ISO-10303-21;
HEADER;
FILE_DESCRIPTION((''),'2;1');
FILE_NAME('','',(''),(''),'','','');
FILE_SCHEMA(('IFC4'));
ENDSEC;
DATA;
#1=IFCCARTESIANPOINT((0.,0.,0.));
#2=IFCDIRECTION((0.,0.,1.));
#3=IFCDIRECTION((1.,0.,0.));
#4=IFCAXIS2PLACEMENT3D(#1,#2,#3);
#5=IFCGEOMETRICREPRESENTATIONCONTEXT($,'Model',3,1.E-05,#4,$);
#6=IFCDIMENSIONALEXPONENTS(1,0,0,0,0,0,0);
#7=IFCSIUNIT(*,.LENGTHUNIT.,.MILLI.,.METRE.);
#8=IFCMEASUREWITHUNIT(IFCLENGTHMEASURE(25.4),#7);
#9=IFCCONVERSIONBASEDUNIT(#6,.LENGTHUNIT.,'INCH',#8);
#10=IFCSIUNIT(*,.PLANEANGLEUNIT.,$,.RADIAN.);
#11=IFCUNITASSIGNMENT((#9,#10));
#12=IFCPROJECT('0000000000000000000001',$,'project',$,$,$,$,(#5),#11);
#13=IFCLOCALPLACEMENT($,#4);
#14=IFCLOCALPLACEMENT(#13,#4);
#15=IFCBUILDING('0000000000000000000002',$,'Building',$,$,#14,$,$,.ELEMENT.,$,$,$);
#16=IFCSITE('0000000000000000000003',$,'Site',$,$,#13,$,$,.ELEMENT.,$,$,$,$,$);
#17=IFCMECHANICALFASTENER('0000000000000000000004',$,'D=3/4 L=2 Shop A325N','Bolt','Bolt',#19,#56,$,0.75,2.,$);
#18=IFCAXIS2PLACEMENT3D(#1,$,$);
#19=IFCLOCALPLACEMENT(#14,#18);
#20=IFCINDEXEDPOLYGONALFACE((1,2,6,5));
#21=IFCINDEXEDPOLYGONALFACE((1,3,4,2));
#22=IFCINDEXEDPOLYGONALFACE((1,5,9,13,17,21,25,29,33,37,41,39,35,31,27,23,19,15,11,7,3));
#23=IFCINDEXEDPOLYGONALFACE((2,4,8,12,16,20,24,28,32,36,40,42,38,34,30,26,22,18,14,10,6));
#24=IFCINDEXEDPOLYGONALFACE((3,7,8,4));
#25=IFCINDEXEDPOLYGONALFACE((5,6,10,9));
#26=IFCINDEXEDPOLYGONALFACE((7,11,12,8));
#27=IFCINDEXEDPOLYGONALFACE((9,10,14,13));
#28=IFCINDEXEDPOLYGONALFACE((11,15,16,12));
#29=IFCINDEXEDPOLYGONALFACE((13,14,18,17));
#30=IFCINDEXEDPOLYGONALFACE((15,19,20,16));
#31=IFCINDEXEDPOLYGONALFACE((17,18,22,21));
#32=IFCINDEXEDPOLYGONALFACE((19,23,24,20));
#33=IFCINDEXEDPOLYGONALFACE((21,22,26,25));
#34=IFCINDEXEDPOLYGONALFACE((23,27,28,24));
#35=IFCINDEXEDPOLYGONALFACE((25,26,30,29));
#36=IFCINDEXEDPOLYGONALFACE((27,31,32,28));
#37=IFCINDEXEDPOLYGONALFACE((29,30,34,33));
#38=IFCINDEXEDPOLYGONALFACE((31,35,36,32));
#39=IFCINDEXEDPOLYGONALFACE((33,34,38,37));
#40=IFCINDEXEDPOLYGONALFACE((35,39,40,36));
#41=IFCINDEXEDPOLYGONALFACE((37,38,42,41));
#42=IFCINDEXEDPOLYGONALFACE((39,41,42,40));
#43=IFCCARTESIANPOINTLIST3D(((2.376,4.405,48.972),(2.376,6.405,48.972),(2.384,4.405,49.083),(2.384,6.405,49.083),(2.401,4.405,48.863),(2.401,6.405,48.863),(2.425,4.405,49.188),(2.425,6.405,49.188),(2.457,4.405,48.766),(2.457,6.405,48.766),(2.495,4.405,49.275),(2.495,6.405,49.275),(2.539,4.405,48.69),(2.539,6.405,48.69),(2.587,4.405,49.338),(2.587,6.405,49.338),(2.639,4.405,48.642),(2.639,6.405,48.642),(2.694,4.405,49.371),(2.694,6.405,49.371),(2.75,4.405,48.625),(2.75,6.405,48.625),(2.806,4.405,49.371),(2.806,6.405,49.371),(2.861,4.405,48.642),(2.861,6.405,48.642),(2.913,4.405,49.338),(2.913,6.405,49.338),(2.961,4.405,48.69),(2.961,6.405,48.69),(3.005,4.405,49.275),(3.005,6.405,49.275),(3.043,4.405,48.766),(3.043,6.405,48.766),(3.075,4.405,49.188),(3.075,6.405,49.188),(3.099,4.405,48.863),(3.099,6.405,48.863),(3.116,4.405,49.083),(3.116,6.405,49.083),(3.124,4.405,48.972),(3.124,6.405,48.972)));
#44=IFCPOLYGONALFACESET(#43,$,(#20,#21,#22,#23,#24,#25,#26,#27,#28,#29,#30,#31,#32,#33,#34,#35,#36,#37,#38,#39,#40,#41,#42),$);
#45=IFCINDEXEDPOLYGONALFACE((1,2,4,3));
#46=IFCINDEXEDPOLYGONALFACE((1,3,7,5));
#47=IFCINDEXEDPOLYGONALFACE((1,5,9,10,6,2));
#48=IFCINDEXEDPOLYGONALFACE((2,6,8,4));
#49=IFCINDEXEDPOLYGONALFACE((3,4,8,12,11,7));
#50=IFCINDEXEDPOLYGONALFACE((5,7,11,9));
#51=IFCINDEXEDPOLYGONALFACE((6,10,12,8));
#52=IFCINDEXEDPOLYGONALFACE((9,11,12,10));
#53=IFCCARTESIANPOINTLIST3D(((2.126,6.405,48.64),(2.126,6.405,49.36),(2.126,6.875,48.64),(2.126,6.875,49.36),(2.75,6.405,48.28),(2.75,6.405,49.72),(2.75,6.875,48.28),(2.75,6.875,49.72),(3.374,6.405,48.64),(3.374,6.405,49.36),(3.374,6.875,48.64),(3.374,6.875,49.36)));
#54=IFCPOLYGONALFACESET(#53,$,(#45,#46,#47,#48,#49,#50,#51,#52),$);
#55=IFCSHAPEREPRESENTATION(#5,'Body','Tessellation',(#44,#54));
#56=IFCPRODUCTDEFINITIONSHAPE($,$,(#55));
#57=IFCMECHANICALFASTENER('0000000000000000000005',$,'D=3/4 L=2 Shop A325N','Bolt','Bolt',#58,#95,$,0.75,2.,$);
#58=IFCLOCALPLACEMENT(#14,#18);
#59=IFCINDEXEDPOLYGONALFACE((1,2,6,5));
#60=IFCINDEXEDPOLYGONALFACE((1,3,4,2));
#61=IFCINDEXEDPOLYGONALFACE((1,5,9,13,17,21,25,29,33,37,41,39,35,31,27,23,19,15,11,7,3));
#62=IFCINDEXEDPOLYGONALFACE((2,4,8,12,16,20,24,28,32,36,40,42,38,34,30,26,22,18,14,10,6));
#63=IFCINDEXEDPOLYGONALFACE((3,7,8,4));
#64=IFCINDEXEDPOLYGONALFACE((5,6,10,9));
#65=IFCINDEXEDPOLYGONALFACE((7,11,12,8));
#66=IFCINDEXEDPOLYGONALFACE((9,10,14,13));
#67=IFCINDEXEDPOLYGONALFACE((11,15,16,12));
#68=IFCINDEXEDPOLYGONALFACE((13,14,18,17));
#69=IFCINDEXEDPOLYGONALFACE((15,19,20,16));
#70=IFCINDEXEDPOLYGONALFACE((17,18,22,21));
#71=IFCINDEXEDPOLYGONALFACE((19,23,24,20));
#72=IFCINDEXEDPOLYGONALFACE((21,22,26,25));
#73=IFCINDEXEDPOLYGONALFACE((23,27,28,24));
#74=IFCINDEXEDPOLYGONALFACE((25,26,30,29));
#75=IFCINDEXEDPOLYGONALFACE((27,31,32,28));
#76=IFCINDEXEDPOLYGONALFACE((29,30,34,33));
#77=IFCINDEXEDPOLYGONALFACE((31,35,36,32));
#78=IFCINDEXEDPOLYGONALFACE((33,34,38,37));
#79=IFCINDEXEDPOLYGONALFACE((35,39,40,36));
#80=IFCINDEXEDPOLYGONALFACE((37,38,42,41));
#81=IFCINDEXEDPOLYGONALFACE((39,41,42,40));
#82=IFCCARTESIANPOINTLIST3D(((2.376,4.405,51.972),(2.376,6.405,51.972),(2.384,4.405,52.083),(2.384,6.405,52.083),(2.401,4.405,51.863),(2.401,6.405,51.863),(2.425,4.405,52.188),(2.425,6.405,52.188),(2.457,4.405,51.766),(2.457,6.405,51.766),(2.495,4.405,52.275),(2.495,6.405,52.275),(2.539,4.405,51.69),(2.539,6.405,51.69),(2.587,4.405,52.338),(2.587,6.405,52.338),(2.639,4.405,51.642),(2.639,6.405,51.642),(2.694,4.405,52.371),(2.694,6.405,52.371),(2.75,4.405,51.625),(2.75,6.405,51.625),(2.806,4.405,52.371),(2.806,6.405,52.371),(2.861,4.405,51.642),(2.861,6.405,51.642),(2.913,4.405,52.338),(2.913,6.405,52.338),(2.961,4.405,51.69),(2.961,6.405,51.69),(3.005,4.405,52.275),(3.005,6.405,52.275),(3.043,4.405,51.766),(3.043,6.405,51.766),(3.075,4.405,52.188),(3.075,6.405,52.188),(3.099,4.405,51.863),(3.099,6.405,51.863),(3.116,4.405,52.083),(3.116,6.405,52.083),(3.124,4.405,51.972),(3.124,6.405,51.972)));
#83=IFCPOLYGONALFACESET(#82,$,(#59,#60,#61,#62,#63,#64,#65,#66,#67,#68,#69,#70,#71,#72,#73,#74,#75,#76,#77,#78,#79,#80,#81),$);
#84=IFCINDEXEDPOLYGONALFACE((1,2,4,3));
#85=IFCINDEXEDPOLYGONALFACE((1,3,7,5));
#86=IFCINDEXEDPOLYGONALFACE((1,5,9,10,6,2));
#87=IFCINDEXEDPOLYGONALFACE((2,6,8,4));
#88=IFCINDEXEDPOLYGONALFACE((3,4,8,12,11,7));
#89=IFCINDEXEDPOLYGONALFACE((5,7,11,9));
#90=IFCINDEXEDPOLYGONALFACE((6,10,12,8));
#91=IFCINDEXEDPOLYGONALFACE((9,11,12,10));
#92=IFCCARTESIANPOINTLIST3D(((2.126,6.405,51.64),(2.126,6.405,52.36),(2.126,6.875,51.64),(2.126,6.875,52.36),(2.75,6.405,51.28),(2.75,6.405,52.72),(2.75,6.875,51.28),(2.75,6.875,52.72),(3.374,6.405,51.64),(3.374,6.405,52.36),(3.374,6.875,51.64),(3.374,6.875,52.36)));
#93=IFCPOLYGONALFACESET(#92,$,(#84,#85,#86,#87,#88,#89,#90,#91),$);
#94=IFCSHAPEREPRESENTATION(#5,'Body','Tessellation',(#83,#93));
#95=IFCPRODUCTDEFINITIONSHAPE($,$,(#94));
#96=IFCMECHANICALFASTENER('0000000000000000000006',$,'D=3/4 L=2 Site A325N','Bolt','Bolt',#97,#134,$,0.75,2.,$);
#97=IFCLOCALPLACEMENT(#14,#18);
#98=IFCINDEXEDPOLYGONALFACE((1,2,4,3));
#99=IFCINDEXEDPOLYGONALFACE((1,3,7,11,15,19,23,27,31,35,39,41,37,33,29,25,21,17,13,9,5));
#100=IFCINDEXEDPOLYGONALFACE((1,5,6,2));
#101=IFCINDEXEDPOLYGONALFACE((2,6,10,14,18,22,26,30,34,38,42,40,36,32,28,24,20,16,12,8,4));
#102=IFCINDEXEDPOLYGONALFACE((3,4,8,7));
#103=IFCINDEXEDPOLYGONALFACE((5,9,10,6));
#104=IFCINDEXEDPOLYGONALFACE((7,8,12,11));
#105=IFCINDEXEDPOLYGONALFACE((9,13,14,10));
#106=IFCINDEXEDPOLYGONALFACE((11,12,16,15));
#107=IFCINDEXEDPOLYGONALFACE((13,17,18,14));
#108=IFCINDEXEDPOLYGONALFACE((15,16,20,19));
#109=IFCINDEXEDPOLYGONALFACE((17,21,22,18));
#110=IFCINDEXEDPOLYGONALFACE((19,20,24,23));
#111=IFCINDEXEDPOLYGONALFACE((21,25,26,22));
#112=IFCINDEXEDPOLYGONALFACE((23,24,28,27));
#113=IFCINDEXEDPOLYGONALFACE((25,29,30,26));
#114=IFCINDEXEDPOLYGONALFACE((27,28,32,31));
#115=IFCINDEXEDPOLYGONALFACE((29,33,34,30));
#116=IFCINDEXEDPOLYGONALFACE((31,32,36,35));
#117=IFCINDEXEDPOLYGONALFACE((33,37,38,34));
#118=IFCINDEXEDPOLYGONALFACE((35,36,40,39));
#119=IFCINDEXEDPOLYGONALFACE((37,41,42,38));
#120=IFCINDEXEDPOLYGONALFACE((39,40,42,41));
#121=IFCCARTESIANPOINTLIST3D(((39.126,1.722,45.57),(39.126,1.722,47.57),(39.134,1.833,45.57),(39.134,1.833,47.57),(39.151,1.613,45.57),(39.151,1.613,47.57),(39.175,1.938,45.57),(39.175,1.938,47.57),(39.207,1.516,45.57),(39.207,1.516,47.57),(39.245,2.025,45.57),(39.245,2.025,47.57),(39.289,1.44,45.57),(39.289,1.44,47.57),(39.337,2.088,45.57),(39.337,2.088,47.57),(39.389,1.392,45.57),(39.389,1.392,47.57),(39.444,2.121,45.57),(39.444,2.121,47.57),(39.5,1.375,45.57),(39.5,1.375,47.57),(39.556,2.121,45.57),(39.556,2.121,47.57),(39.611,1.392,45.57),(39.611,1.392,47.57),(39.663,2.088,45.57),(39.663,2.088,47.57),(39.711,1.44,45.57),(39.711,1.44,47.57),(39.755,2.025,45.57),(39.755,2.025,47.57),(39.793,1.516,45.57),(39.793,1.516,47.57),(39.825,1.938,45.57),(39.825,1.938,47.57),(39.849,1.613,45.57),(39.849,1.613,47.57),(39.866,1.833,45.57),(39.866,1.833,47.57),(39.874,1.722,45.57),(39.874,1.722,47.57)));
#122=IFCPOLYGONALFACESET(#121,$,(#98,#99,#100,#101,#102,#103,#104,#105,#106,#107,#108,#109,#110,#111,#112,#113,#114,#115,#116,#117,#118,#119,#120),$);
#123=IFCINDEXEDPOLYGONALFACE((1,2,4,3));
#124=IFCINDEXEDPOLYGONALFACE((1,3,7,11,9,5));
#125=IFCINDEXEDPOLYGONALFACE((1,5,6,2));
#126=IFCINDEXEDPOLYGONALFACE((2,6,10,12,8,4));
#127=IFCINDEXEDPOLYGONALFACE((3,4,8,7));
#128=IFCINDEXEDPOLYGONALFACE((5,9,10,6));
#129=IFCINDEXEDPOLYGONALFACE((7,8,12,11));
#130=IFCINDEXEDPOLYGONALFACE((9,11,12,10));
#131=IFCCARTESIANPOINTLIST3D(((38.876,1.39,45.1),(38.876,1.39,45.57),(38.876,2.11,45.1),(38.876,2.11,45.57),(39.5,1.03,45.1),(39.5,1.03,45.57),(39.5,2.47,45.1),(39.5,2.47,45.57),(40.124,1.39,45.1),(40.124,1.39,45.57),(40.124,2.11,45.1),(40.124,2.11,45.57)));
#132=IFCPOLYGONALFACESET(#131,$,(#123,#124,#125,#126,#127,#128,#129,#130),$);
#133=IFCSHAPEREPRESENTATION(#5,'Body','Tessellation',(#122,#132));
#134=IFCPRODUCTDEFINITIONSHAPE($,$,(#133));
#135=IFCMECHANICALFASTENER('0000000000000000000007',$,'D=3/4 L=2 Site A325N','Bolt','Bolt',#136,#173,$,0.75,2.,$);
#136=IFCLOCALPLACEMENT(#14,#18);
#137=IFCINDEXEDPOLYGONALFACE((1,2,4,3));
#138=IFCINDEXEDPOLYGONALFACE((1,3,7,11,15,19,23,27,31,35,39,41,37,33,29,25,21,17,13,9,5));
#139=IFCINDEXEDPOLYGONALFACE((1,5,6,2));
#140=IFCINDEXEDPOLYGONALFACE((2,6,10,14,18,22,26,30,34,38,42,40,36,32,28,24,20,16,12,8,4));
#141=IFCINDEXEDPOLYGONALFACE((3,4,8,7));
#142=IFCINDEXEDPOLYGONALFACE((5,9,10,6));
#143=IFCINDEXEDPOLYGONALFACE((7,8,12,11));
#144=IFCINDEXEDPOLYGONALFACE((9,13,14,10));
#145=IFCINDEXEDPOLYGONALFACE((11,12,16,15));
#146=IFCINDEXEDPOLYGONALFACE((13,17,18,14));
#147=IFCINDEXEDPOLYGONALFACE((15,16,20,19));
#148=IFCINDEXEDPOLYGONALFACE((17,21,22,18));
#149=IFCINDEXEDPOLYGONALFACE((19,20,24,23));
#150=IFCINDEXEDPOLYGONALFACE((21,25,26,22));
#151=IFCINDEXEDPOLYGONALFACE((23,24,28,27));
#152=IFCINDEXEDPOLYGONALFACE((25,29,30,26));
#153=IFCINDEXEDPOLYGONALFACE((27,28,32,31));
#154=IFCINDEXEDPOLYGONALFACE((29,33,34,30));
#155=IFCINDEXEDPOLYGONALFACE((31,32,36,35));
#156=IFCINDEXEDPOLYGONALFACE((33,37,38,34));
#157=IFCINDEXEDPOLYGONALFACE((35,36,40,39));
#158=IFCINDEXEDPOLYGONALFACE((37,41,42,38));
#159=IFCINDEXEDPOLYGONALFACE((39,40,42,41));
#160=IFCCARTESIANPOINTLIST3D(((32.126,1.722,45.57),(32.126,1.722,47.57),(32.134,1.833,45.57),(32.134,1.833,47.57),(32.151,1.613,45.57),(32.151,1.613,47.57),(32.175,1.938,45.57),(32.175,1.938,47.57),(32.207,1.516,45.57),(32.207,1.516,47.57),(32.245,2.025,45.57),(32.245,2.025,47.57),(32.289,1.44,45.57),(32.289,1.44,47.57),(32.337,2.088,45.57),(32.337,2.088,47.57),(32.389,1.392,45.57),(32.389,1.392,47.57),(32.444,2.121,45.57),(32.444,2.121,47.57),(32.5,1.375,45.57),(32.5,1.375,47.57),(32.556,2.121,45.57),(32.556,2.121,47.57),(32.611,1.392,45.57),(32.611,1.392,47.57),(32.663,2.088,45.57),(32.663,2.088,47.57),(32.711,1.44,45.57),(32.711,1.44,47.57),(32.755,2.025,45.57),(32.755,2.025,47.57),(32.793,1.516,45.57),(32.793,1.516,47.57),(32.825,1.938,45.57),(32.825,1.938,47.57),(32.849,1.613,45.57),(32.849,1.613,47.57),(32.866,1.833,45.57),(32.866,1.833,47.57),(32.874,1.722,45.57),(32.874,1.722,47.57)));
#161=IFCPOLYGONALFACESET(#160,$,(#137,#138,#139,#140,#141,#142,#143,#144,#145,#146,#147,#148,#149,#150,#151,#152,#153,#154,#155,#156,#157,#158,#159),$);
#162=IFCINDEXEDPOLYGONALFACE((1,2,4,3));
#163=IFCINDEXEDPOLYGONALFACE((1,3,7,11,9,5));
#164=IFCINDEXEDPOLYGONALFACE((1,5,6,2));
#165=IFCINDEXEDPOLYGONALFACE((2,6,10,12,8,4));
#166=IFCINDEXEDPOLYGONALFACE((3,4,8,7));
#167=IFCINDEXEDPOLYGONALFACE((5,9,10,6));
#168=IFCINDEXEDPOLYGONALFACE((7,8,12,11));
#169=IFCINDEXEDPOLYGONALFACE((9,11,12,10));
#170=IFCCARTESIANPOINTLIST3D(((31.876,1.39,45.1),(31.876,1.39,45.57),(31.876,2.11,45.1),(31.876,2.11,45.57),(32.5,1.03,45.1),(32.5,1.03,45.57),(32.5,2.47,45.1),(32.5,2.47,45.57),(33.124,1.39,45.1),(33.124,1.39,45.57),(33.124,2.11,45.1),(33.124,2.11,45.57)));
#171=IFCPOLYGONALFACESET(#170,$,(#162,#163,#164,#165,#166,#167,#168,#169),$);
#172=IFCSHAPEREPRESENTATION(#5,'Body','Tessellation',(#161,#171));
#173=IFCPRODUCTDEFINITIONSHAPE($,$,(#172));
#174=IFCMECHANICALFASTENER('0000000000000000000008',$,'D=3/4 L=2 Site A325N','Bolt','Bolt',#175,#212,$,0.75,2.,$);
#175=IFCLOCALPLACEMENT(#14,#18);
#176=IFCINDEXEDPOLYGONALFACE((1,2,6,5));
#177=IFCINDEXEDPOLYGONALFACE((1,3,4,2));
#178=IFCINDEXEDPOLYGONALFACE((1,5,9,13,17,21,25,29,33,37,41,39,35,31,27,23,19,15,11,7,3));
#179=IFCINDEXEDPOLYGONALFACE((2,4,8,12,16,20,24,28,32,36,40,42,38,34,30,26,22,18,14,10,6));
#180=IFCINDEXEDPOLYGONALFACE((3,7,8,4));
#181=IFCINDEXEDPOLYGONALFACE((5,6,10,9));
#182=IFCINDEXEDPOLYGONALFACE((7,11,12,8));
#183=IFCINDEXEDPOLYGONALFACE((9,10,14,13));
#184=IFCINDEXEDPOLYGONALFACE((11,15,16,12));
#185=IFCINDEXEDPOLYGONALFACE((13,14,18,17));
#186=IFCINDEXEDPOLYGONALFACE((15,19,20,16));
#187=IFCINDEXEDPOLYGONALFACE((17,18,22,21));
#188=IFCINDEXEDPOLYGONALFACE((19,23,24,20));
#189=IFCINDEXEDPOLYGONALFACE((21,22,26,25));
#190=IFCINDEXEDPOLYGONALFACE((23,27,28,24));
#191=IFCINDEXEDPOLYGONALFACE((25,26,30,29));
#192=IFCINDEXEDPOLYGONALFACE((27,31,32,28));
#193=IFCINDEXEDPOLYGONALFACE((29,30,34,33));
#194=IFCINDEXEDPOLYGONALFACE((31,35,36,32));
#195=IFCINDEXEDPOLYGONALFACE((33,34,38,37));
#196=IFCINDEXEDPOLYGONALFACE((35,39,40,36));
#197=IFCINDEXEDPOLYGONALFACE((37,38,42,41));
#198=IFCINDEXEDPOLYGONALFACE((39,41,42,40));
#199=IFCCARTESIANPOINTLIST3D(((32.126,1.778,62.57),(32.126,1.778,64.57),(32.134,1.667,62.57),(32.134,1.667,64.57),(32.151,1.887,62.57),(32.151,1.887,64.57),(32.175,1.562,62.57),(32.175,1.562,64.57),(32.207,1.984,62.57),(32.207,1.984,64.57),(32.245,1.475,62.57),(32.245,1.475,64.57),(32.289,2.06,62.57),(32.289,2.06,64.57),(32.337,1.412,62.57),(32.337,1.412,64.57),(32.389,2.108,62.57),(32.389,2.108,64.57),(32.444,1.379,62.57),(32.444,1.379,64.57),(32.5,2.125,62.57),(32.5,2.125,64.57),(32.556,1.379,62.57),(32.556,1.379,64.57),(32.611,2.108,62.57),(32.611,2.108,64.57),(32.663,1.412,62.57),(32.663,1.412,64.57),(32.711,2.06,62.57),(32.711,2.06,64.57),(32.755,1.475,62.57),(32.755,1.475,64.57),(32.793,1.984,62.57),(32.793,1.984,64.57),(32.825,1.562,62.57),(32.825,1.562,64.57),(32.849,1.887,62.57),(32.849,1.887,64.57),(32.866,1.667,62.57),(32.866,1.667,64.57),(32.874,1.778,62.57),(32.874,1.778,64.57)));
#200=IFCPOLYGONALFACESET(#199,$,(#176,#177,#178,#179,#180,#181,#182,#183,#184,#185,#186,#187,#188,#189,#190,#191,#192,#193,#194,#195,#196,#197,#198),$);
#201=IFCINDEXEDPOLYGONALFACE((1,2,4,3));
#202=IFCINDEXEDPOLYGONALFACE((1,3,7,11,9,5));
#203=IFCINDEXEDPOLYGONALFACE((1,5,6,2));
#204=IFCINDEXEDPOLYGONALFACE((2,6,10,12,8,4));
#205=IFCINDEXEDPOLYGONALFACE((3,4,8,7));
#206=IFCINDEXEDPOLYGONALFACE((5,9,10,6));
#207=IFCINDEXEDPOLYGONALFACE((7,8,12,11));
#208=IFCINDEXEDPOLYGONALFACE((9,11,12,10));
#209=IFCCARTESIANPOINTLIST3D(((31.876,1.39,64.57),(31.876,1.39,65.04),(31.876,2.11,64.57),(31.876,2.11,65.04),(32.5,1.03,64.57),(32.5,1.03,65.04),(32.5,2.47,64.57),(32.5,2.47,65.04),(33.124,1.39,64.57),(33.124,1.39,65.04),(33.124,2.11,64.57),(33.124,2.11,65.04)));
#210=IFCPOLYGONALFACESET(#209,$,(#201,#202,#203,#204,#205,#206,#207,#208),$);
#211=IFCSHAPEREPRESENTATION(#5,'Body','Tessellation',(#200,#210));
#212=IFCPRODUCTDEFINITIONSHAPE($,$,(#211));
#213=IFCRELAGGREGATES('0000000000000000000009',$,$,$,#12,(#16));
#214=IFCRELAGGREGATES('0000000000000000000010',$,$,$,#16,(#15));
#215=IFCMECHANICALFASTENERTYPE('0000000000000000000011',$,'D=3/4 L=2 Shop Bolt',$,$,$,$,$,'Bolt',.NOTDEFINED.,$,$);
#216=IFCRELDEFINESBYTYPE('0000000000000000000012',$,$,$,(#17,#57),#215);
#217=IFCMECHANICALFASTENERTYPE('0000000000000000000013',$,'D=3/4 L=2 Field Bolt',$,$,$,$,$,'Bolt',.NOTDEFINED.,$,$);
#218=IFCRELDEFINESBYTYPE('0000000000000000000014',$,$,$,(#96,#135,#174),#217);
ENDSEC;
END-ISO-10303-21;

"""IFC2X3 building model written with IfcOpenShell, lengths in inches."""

from ifc_helpers import new_model, entity, si_unit, converted_unit, frame, origin_with_axes, origin_2d_with_axis, place, context, project, spatial, polyline, circle, outline, extrude, source, transform, mapped, type_object, type_shapes, element, save


model = new_model("IFC2X3")

# Units and contexts
model_context = context("Model", 3, precision=1e-05, world=origin_with_axes())
ifc_project = project(units=[converted_unit("LENGTHUNIT", "INCH", entity("IfcLengthMeasure", 25.4), si_unit("LENGTHUNIT", "METRE", prefix="MILLI"), dimensions=[1, 0, 0, 0, 0, 0, 0]), si_unit("PLANEANGLEUNIT", "RADIAN")], contexts=[model_context])

# Site, building
site_placement = place(None, origin_with_axes())
site = spatial("IfcSite", under=ifc_project, at=site_placement, Name="Site", CompositionType="ELEMENT")
building_placement = place(site_placement, origin_with_axes())
building = spatial("IfcBuilding", under=site, at=building_placement, Name="Building", CompositionType="ELEMENT")

# Mechanical fasteners
mechanical_fastener_type_1 = type_object("IfcMechanicalFastenerType", Name="D=3/4 L=2 Shop Bolt", ElementType="Bolt")
shared_shape_1 = source(origin_with_axes(), model_context, "Body", "SweptSolid", [
    extrude(circle(Radius=0.375, at=origin_2d_with_axis()), frame((0.0, 0.0, 0.0), z_axis=(1.0, 0.0, 0.0), x_axis=(0.0, 1.0, 0.0)), (0.0, 0.0, 1.0), 2.0),
    extrude(outline(polyline([(-0.72, 0.0), (-0.36, 0.624), (0.36, 0.624), (0.72, 0.0), (0.36, -0.624), (-0.36, -0.624), (-0.72, 0.0)])), frame((0.0, 0.0, 0.0), z_axis=(1.0, 0.0, 0.0), x_axis=(0.0, 1.0, 0.0)), (0.0, 0.0, -1.0), 0.47),
])
type_shapes(mechanical_fastener_type_1, [shared_shape_1])
placement_1 = place(building_placement, frame((0.0, 0.0, 21.0), z_axis=(0.0, -1.0, 0.0), x_axis=(0.0, 0.0, 1.0)))
placement_2 = place(placement_1, frame((31.0, 2.75, -6.405), z_axis=(0.0, -1.0, 0.0), x_axis=(0.0, 0.0, 1.0)))
for number, where, z_axis, x_axis, name in (
    (1, (0.0, 3.0, 5.5), (0.0, 0.0, 1.0), (1.0, 0.0, 0.0), "D=3/4 L=2 Shop A325N"),
    (2, (0.0, 0.0, 5.5), (0.0, 0.0, 1.0), (1.0, 0.0, 0.0), "D=3/4 L=2 Shop A325N"),
):
    element("IfcMechanicalFastener", number, at=place(placement_2, frame(where, z_axis=z_axis, x_axis=x_axis)), type_object=mechanical_fastener_type_1, Name=name, Description="Bolt", ObjectType="Bolt", NominalDiameter=0.75, NominalLength=2.0, context=model_context, shape_type="MappedRepresentation", body=[
        mapped(shared_shape_1, transform((0.0, 0.0, 0.0), scale=1.0)),
    ])
mechanical_fastener_type_2 = type_object("IfcMechanicalFastenerType", Name="D=3/4 L=2 Field Bolt", ElementType="Bolt")
shared_shape_2 = source(origin_with_axes(), model_context, "Body", "SweptSolid", [
    extrude(circle(Radius=0.375, at=origin_2d_with_axis()), frame((0.0, 0.0, 0.0), z_axis=(1.0, 0.0, 0.0), x_axis=(0.0, 1.0, 0.0)), (0.0, 0.0, 1.0), 2.0),
    extrude(outline(polyline([(-0.72, 0.0), (-0.36, 0.624), (0.36, 0.624), (0.72, 0.0), (0.36, -0.624), (-0.36, -0.624), (-0.72, 0.0)])), frame((0.0, 0.0, 0.0), z_axis=(1.0, 0.0, 0.0), x_axis=(0.0, 1.0, 0.0)), (0.0, 0.0, -1.0), 0.47),
])
type_shapes(mechanical_fastener_type_2, [shared_shape_2])
placement_3 = place(building_placement, frame((36.0, 0.0, 46.0), z_axis=(-1.0, 0.0, 0.0), x_axis=(0.0, 0.0, 1.0)))
placement_4 = place(placement_3, frame((-0.43, 1.75, 3.5), z_axis=(0.0, 0.0, -1.0), x_axis=(1.0, 0.0, 0.0)))
for number, where, z_axis, x_axis, name in (
    (3, (0.0, 0.0, 7.0), (0.0, 0.0, 1.0), (1.0, 0.0, 0.0), "D=3/4 L=2 Site A325N"),
    (4, (0.0, 0.0, 0.0), (0.0, 0.0, 1.0), (1.0, 0.0, 0.0), "D=3/4 L=2 Site A325N"),
):
    element("IfcMechanicalFastener", number, at=place(placement_4, frame(where, z_axis=z_axis, x_axis=x_axis)), type_object=mechanical_fastener_type_2, Name=name, Description="Bolt", ObjectType="Bolt", NominalDiameter=0.75, NominalLength=2.0, context=model_context, shape_type="MappedRepresentation", body=[
        mapped(shared_shape_2, transform((0.0, 0.0, 0.0), scale=1.0)),
    ])
placement_5 = place(placement_3, frame((18.57, -1.75, 3.5), z_axis=(0.0, 0.0, -1.0), x_axis=(-1.0, 0.0, 0.0)))
for number, where, z_axis, x_axis, name in (
    (5, (0.0, 3.5, 0.0), (0.0, 0.0, 1.0), (1.0, 0.0, 0.0), "D=3/4 L=2 Site A325N"),
):
    element("IfcMechanicalFastener", number, at=place(placement_5, frame(where, z_axis=z_axis, x_axis=x_axis)), type_object=mechanical_fastener_type_2, Name=name, Description="Bolt", ObjectType="Bolt", NominalDiameter=0.75, NominalLength=2.0, context=model_context, shape_type="MappedRepresentation", body=[
        mapped(shared_shape_2, transform((0.0, 0.0, 0.0), scale=1.0)),
    ])

save(model, "model.ifc")
